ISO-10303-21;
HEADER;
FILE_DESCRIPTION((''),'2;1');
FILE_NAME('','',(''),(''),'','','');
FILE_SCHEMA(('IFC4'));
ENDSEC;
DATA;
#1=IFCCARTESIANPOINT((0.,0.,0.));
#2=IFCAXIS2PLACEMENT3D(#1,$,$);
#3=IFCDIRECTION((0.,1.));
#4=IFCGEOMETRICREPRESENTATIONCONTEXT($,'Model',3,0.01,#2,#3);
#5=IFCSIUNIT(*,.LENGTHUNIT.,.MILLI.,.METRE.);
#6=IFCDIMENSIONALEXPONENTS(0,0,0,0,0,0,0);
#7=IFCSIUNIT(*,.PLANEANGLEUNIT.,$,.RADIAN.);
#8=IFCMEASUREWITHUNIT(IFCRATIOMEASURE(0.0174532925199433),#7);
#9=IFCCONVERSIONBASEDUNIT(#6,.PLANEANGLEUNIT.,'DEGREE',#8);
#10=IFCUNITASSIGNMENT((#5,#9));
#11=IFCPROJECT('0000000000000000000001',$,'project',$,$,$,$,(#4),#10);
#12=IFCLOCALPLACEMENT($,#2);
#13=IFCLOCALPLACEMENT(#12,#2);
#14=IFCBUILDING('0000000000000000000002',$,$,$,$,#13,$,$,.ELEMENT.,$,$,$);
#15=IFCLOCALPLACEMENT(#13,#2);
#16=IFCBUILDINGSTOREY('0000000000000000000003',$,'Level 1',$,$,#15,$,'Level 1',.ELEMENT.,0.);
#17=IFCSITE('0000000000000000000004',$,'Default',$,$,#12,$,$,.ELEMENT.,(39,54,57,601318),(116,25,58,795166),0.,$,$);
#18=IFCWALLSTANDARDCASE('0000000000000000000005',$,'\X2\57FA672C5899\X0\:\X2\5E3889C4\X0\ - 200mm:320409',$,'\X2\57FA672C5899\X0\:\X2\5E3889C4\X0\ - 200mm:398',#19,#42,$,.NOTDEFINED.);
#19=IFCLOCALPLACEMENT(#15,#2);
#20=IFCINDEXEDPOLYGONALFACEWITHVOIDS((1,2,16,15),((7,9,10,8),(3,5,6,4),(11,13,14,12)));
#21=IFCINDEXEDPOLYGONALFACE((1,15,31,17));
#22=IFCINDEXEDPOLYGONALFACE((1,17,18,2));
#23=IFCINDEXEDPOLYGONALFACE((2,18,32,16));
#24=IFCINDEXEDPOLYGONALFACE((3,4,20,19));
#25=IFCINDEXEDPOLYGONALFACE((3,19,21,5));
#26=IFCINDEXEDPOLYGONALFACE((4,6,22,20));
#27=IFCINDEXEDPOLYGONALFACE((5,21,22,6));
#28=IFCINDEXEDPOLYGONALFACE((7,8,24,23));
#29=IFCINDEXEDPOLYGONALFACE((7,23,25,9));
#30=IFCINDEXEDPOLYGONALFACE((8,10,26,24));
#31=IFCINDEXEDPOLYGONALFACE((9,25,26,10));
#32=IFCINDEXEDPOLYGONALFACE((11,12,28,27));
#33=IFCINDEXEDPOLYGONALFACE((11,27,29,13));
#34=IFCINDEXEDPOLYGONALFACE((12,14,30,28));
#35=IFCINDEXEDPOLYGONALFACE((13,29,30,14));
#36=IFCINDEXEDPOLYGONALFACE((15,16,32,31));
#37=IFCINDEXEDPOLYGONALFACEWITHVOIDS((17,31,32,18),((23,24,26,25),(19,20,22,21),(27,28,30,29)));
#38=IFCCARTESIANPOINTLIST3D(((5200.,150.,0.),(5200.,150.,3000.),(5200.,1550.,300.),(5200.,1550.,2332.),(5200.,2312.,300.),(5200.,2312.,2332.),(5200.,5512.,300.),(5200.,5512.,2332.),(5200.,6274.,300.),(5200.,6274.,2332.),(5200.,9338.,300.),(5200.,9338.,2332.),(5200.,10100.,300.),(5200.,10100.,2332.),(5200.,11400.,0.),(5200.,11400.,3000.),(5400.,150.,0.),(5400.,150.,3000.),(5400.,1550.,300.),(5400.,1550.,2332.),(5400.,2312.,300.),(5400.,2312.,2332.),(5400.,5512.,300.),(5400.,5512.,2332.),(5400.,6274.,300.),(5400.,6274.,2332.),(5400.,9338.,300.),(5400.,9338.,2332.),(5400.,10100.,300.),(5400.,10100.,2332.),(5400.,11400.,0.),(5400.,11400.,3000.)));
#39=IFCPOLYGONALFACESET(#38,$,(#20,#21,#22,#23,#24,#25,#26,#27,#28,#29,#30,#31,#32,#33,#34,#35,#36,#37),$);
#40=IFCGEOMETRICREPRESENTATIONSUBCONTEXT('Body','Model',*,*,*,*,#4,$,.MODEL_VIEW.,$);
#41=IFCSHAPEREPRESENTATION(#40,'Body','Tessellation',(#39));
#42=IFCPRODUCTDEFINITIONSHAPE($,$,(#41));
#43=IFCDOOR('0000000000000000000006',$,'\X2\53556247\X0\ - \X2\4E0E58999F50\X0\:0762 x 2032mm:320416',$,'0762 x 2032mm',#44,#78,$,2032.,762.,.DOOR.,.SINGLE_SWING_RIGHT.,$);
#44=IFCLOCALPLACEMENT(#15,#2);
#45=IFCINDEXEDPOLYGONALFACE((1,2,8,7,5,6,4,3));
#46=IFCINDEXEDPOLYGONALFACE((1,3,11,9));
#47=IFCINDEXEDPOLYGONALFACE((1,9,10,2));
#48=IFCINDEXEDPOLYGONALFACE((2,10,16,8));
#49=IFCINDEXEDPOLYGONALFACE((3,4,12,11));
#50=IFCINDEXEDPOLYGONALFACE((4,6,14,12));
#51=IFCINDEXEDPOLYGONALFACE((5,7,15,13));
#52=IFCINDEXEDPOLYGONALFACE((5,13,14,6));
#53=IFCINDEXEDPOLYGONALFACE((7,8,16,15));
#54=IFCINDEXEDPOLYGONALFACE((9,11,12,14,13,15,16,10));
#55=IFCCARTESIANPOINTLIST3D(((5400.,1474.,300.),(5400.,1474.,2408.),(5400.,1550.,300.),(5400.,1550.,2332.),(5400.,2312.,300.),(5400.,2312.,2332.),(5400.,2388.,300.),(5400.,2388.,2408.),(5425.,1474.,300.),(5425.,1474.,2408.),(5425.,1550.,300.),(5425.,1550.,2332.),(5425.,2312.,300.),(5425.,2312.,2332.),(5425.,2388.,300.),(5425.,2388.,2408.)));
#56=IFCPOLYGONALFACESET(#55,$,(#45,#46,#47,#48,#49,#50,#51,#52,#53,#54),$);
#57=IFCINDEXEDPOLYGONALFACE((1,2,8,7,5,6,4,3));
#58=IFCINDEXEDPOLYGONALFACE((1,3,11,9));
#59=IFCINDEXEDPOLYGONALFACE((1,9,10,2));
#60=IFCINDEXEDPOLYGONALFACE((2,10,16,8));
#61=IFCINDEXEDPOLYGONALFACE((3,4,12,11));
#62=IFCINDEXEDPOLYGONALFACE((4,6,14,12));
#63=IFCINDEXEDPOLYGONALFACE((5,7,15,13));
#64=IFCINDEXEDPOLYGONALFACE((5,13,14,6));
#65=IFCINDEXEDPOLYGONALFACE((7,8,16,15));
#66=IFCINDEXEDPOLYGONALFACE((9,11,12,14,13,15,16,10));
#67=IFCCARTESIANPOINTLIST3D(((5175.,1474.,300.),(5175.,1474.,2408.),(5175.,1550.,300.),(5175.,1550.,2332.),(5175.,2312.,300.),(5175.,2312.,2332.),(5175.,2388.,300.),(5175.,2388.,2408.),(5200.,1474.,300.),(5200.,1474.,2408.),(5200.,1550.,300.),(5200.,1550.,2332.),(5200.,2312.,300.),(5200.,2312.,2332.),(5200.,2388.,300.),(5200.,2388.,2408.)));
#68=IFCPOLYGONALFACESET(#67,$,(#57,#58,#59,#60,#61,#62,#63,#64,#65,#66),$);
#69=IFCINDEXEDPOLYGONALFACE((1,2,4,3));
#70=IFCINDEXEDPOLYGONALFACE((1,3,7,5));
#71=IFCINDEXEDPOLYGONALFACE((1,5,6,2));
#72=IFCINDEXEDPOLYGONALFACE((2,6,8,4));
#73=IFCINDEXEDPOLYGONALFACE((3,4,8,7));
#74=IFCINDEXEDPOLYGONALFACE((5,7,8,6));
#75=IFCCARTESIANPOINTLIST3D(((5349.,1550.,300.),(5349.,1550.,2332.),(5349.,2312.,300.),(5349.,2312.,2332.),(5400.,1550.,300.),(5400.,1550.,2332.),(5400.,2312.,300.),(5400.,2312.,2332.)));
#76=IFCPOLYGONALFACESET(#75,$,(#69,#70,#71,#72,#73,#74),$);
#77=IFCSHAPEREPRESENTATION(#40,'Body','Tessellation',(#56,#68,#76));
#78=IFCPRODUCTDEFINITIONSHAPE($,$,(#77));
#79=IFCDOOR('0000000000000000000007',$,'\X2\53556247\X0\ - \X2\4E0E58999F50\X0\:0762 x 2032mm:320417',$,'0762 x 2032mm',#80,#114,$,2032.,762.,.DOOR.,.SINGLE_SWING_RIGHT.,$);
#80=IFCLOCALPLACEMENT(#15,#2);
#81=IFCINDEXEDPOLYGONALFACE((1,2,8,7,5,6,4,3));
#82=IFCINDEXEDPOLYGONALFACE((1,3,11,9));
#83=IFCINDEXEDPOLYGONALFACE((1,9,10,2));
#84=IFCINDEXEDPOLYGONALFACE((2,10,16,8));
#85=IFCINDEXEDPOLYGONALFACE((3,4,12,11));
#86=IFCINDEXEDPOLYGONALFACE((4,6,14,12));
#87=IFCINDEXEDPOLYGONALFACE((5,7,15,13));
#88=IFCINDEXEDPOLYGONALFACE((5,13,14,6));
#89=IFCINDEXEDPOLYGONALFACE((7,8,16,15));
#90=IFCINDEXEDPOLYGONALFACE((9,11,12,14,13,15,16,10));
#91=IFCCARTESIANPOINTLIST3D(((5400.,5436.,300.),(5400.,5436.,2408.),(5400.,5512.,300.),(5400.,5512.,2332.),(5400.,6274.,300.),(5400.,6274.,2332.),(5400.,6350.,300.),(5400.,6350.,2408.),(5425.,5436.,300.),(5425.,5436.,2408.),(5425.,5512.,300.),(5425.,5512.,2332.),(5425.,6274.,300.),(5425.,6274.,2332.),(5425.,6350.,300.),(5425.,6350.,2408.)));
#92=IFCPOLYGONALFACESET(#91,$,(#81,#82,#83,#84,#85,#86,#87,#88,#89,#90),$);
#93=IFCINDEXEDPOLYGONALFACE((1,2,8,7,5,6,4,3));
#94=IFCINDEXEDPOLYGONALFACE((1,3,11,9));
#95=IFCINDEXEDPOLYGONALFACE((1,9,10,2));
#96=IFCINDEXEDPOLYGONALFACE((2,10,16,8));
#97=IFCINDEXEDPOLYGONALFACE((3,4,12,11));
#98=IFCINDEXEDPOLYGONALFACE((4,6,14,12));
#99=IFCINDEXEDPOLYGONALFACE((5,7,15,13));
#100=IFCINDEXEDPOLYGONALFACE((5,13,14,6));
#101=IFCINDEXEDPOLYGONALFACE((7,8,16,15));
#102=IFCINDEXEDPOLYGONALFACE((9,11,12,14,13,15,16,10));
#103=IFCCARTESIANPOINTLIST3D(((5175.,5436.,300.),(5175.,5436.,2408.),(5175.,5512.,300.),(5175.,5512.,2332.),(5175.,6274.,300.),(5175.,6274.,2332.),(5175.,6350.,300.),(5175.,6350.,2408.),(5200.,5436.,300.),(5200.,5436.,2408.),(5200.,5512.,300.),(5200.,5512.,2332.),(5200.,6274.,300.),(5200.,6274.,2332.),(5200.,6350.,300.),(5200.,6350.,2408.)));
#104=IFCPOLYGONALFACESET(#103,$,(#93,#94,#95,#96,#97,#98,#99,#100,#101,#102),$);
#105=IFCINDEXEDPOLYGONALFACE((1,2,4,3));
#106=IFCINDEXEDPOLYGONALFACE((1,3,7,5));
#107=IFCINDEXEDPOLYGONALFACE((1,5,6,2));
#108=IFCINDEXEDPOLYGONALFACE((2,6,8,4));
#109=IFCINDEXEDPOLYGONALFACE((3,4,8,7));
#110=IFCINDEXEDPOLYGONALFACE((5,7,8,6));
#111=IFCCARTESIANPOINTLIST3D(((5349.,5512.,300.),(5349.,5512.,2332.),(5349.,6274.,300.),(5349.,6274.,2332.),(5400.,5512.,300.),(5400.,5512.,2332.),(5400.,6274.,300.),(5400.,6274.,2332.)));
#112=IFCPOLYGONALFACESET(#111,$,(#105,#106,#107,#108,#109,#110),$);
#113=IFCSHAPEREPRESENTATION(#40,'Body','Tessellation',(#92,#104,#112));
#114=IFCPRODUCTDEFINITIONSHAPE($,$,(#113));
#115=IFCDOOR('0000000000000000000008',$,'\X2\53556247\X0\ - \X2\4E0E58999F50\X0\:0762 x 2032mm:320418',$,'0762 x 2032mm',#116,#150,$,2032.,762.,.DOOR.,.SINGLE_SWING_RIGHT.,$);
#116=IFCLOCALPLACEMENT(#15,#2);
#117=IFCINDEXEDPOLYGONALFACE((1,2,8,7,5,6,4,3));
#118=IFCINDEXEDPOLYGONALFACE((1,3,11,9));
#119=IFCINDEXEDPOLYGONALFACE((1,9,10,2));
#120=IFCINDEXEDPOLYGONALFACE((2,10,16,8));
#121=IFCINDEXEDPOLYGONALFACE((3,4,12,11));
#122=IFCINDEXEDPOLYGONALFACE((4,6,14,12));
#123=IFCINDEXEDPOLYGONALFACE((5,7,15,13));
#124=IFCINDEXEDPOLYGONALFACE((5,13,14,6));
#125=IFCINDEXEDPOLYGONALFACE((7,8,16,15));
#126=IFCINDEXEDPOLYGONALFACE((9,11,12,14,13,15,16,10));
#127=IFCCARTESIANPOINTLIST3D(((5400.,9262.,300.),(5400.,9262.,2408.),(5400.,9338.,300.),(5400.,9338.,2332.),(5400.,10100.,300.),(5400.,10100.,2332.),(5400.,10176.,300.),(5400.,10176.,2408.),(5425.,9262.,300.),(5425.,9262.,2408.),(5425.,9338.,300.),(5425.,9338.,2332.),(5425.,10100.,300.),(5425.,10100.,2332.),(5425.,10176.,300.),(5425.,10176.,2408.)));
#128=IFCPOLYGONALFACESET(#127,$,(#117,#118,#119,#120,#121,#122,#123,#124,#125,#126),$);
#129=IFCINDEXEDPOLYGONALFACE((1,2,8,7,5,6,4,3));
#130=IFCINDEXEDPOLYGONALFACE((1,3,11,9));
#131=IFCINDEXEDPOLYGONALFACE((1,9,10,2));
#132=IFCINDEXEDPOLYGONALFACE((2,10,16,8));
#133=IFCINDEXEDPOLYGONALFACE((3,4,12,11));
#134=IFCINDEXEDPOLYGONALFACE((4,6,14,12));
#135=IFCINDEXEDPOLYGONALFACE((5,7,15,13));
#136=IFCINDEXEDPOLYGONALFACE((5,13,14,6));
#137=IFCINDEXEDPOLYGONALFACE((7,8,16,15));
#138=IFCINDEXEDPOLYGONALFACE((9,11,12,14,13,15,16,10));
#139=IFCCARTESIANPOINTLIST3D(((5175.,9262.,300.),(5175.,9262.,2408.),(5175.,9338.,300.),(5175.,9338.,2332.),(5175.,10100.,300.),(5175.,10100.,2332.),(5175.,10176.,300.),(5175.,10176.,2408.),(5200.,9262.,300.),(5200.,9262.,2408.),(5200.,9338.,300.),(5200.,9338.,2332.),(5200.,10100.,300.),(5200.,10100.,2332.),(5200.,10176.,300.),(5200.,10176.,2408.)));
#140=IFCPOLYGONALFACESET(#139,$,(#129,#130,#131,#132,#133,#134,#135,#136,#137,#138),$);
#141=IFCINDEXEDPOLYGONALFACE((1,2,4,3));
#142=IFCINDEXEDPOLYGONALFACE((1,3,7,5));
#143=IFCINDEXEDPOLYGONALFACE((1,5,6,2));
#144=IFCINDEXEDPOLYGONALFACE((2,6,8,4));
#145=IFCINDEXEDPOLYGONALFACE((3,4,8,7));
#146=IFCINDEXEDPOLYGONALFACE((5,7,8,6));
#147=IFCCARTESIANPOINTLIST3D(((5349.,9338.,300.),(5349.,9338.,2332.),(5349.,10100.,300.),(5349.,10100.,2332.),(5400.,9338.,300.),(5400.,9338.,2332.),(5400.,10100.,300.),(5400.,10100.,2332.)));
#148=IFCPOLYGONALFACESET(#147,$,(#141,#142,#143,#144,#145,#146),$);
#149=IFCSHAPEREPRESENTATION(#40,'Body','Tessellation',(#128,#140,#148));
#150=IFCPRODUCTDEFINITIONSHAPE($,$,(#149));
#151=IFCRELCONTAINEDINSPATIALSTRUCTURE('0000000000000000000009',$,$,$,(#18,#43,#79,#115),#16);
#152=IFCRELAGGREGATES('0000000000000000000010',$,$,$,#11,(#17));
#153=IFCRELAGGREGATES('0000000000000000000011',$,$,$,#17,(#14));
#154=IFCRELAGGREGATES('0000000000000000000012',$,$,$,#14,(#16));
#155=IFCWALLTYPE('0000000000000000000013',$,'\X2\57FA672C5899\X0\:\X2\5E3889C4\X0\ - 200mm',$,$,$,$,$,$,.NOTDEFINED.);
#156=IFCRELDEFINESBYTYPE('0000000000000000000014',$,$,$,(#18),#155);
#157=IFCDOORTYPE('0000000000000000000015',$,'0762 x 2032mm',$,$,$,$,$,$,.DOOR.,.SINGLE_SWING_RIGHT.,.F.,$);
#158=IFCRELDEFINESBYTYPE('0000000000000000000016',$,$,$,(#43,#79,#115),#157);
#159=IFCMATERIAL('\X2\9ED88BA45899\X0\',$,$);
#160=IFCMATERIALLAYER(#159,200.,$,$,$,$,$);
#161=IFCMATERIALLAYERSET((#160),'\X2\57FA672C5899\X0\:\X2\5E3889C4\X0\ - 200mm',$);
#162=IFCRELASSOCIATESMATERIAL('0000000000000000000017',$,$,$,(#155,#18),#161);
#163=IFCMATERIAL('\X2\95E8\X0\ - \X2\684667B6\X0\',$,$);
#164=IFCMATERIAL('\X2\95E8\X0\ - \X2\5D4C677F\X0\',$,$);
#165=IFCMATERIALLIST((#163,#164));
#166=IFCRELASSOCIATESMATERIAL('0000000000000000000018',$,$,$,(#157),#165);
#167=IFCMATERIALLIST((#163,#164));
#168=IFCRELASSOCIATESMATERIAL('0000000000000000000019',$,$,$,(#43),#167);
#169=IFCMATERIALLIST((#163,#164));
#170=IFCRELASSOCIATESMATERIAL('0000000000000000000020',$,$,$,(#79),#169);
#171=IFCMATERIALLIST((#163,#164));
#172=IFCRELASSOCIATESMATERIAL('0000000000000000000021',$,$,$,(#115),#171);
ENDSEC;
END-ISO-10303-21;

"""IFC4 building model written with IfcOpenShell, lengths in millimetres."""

from ifc_helpers import new_model, entity, si_unit, converted_unit, direction, frame, frame_2d, origin, origin_2d_with_axis, place, context, subcontext, project, spatial, polyline, rectangle, outline, extrude, source, transform, mapped, material, material_list, layer, layer_set, layer_usage, type_object, type_shapes, element, fill, save


model = new_model("IFC4")

# Units and contexts
model_context = context("Model", 3, precision=0.01, world=origin(), true_north=direction((0.0, 1.0)))
body_context = subcontext(model_context, "Body", "Model", "MODEL_VIEW")
ifc_project = project(units=[si_unit("LENGTHUNIT", "METRE", prefix="MILLI"), converted_unit("PLANEANGLEUNIT", "DEGREE", entity("IfcRatioMeasure", 0.0174532925199433), si_unit("PLANEANGLEUNIT", "RADIAN"), dimensions=[0, 0, 0, 0, 0, 0, 0])], contexts=[model_context])

# Site, building, storey
site_placement = place(None, origin())
site = spatial("IfcSite", under=ifc_project, at=site_placement, Name="Default", CompositionType="ELEMENT", RefLatitude=(39, 54, 57, 601318), RefLongitude=(116, 25, 58, 795166), RefElevation=0.0)
building_placement = place(site_placement, origin())
building = spatial("IfcBuilding", under=site, at=building_placement, CompositionType="ELEMENT")
storey_placement = place(building_placement, origin())
storey = spatial("IfcBuildingStorey", under=building, at=storey_placement, Name="Level 1", LongName="Level 1", CompositionType="ELEMENT", Elevation=0.0)

# Shared definitions
ifc_material_1 = material(Name="默认墙")
ifc_layer = layer(ifc_material_1, 200.0)
ifc_layer_set = layer_set([ifc_layer], Name="基本墙:常规 - 200mm")
wall_type = type_object("IfcWallType", Name="基本墙:常规 - 200mm", PredefinedType="NOTDEFINED", material=ifc_layer_set)

# Wall, openings, doors
ifc_layer_usage_1 = layer_usage(ifc_layer_set, "AXIS2", "NEGATIVE", 100.0)
wall_1_placement = place(storey_placement, frame((5300.0, 11400.0, 0.0), z_axis=(0.0, 0.0, 1.0), x_axis=(0.0, -1.0, 0.0)))
wall_1 = element("IfcWallStandardCase", 1, at=wall_1_placement, inside=storey, type_object=wall_type, material=ifc_layer_usage_1, Name="基本墙:常规 - 200mm:320409", ObjectType="基本墙:常规 - 200mm:398", PredefinedType="NOTDEFINED", context=body_context, shape_type="SweptSolid", body=[
    extrude(rectangle(XDim=11250.0, YDim=200.0, at=frame_2d((5625.0, 0.0), x_axis=(-1.0, 0.0))), origin(), (0.0, 0.0, 1.0), 3000.0),
])
opening_1_placement = place(wall_1_placement, frame((9088.0, -100.0, 300.0)))
opening_1 = element("IfcOpeningElement", 2, at=opening_1_placement, cuts=wall_1, ObjectType="Opening", PredefinedType="OPENING", context=body_context, shape_type="SweptSolid", body=[
    extrude(rectangle(XDim=762.0, YDim=2032.0, at=frame_2d((1016.0, 381.0), x_axis=(0.0, 1.0))), frame((0.0, 0.0, 0.0), z_axis=(0.0, 1.0, 0.0), x_axis=(0.0, 0.0, 1.0)), (0.0, 0.0, 1.0), 200.0),
])
opening_2_placement = place(wall_1_placement, frame((5126.0, -100.0, 300.0)))
opening_2 = element("IfcOpeningElement", 3, at=opening_2_placement, cuts=wall_1, ObjectType="Opening", PredefinedType="OPENING", context=body_context, shape_type="SweptSolid", body=[
    extrude(rectangle(XDim=762.0, YDim=2032.0, at=frame_2d((1016.0, 381.0), x_axis=(0.0, 1.0))), frame((0.0, 0.0, 0.0), z_axis=(0.0, 1.0, 0.0), x_axis=(0.0, 0.0, 1.0)), (0.0, 0.0, 1.0), 200.0),
])
opening_3_placement = place(wall_1_placement, frame((1300.0, -100.0, 300.0)))
opening_3 = element("IfcOpeningElement", 4, at=opening_3_placement, cuts=wall_1, ObjectType="Opening", PredefinedType="OPENING", context=body_context, shape_type="SweptSolid", body=[
    extrude(rectangle(XDim=762.0, YDim=2032.0, at=frame_2d((1016.0, 381.0), x_axis=(0.0, 1.0))), frame((0.0, 0.0, 0.0), z_axis=(0.0, 1.0, 0.0), x_axis=(0.0, 0.0, 1.0)), (0.0, 0.0, 1.0), 200.0),
])
ifc_material_2 = material(Name="门 - 框架")
ifc_material_3 = material(Name="门 - 嵌板")
ifc_material_list_1 = material_list([ifc_material_2, ifc_material_3])
ifc_material_list_2 = material_list([ifc_material_2, ifc_material_3])
door_type_1 = type_object("IfcDoorType", Name="0762 x 2032mm", OperationType="SINGLE_SWING_RIGHT", ParameterTakesPrecedence=False, PredefinedType="DOOR", material=ifc_material_list_2)
shared_shape_1 = source(origin(), body_context, "Body", "SweptSolid", [
    extrude(outline(polyline([(-457.0, -1073.0), (457.0, -1073.0), (457.0, 1035.0), (381.0, 1035.0), (381.0, -997.0), (-381.0, -997.0), (-381.0, 1035.0), (-457.0, 1035.0), (-457.0, -1073.0)])), frame((381.0, 200.0, 1035.0), z_axis=(0.0, 1.0, 0.0), x_axis=(1.0, 0.0, 0.0)), (0.0, 0.0, 1.0), 25.0),
    extrude(outline(polyline([(-1073.0, -457.0), (1035.0, -457.0), (1035.0, -381.0), (-997.0, -381.0), (-997.0, 381.0), (1035.0, 381.0), (1035.0, 457.0), (-1073.0, 457.0), (-1073.0, -457.0)])), frame((381.0, -25.0, 1035.0), z_axis=(0.0, 1.0, 0.0), x_axis=(0.0, 0.0, -1.0)), (0.0, 0.0, 1.0), 25.0),
    extrude(rectangle(XDim=51.0, YDim=762.0, at=origin_2d_with_axis()), frame((381.0, 174.5, 0.0), z_axis=(0.0, 0.0, 1.0), x_axis=(0.0, 1.0, 0.0)), (0.0, 0.0, 1.0), 2032.0),
])
type_shapes(door_type_1, [shared_shape_1])
door_1_placement = place(opening_1_placement, origin())
door_1 = element("IfcDoor", 5, at=door_1_placement, inside=storey, type_object=door_type_1, material=ifc_material_list_1, Name="单扇 - 与墙齐:0762 x 2032mm:320416", ObjectType="0762 x 2032mm", OperationType="SINGLE_SWING_RIGHT", OverallHeight=2032.0, OverallWidth=762.0, PredefinedType="DOOR", context=body_context, shape_type="MappedRepresentation", body=[
    mapped(shared_shape_1, transform((0.0, 0.0, 0.0), scale=1.0)),
])
fill(opening_1, door_1)
ifc_material_list_3 = material_list([ifc_material_2, ifc_material_3])
door_2_placement = place(opening_2_placement, origin())
door_2 = element("IfcDoor", 6, at=door_2_placement, inside=storey, type_object=door_type_1, material=ifc_material_list_3, Name="单扇 - 与墙齐:0762 x 2032mm:320417", ObjectType="0762 x 2032mm", OperationType="SINGLE_SWING_RIGHT", OverallHeight=2032.0, OverallWidth=762.0, PredefinedType="DOOR", context=body_context, shape_type="MappedRepresentation", body=[
    mapped(shared_shape_1, transform((0.0, 0.0, 0.0), scale=1.0)),
])
fill(opening_2, door_2)
ifc_material_list_4 = material_list([ifc_material_2, ifc_material_3])
door_3_placement = place(opening_3_placement, origin())
door_3 = element("IfcDoor", 7, at=door_3_placement, inside=storey, type_object=door_type_1, material=ifc_material_list_4, Name="单扇 - 与墙齐:0762 x 2032mm:320418", ObjectType="0762 x 2032mm", OperationType="SINGLE_SWING_RIGHT", OverallHeight=2032.0, OverallWidth=762.0, PredefinedType="DOOR", context=body_context, shape_type="MappedRepresentation", body=[
    mapped(shared_shape_1, transform((0.0, 0.0, 0.0), scale=1.0)),
])
fill(opening_3, door_3)

save(model, "model.ifc")
